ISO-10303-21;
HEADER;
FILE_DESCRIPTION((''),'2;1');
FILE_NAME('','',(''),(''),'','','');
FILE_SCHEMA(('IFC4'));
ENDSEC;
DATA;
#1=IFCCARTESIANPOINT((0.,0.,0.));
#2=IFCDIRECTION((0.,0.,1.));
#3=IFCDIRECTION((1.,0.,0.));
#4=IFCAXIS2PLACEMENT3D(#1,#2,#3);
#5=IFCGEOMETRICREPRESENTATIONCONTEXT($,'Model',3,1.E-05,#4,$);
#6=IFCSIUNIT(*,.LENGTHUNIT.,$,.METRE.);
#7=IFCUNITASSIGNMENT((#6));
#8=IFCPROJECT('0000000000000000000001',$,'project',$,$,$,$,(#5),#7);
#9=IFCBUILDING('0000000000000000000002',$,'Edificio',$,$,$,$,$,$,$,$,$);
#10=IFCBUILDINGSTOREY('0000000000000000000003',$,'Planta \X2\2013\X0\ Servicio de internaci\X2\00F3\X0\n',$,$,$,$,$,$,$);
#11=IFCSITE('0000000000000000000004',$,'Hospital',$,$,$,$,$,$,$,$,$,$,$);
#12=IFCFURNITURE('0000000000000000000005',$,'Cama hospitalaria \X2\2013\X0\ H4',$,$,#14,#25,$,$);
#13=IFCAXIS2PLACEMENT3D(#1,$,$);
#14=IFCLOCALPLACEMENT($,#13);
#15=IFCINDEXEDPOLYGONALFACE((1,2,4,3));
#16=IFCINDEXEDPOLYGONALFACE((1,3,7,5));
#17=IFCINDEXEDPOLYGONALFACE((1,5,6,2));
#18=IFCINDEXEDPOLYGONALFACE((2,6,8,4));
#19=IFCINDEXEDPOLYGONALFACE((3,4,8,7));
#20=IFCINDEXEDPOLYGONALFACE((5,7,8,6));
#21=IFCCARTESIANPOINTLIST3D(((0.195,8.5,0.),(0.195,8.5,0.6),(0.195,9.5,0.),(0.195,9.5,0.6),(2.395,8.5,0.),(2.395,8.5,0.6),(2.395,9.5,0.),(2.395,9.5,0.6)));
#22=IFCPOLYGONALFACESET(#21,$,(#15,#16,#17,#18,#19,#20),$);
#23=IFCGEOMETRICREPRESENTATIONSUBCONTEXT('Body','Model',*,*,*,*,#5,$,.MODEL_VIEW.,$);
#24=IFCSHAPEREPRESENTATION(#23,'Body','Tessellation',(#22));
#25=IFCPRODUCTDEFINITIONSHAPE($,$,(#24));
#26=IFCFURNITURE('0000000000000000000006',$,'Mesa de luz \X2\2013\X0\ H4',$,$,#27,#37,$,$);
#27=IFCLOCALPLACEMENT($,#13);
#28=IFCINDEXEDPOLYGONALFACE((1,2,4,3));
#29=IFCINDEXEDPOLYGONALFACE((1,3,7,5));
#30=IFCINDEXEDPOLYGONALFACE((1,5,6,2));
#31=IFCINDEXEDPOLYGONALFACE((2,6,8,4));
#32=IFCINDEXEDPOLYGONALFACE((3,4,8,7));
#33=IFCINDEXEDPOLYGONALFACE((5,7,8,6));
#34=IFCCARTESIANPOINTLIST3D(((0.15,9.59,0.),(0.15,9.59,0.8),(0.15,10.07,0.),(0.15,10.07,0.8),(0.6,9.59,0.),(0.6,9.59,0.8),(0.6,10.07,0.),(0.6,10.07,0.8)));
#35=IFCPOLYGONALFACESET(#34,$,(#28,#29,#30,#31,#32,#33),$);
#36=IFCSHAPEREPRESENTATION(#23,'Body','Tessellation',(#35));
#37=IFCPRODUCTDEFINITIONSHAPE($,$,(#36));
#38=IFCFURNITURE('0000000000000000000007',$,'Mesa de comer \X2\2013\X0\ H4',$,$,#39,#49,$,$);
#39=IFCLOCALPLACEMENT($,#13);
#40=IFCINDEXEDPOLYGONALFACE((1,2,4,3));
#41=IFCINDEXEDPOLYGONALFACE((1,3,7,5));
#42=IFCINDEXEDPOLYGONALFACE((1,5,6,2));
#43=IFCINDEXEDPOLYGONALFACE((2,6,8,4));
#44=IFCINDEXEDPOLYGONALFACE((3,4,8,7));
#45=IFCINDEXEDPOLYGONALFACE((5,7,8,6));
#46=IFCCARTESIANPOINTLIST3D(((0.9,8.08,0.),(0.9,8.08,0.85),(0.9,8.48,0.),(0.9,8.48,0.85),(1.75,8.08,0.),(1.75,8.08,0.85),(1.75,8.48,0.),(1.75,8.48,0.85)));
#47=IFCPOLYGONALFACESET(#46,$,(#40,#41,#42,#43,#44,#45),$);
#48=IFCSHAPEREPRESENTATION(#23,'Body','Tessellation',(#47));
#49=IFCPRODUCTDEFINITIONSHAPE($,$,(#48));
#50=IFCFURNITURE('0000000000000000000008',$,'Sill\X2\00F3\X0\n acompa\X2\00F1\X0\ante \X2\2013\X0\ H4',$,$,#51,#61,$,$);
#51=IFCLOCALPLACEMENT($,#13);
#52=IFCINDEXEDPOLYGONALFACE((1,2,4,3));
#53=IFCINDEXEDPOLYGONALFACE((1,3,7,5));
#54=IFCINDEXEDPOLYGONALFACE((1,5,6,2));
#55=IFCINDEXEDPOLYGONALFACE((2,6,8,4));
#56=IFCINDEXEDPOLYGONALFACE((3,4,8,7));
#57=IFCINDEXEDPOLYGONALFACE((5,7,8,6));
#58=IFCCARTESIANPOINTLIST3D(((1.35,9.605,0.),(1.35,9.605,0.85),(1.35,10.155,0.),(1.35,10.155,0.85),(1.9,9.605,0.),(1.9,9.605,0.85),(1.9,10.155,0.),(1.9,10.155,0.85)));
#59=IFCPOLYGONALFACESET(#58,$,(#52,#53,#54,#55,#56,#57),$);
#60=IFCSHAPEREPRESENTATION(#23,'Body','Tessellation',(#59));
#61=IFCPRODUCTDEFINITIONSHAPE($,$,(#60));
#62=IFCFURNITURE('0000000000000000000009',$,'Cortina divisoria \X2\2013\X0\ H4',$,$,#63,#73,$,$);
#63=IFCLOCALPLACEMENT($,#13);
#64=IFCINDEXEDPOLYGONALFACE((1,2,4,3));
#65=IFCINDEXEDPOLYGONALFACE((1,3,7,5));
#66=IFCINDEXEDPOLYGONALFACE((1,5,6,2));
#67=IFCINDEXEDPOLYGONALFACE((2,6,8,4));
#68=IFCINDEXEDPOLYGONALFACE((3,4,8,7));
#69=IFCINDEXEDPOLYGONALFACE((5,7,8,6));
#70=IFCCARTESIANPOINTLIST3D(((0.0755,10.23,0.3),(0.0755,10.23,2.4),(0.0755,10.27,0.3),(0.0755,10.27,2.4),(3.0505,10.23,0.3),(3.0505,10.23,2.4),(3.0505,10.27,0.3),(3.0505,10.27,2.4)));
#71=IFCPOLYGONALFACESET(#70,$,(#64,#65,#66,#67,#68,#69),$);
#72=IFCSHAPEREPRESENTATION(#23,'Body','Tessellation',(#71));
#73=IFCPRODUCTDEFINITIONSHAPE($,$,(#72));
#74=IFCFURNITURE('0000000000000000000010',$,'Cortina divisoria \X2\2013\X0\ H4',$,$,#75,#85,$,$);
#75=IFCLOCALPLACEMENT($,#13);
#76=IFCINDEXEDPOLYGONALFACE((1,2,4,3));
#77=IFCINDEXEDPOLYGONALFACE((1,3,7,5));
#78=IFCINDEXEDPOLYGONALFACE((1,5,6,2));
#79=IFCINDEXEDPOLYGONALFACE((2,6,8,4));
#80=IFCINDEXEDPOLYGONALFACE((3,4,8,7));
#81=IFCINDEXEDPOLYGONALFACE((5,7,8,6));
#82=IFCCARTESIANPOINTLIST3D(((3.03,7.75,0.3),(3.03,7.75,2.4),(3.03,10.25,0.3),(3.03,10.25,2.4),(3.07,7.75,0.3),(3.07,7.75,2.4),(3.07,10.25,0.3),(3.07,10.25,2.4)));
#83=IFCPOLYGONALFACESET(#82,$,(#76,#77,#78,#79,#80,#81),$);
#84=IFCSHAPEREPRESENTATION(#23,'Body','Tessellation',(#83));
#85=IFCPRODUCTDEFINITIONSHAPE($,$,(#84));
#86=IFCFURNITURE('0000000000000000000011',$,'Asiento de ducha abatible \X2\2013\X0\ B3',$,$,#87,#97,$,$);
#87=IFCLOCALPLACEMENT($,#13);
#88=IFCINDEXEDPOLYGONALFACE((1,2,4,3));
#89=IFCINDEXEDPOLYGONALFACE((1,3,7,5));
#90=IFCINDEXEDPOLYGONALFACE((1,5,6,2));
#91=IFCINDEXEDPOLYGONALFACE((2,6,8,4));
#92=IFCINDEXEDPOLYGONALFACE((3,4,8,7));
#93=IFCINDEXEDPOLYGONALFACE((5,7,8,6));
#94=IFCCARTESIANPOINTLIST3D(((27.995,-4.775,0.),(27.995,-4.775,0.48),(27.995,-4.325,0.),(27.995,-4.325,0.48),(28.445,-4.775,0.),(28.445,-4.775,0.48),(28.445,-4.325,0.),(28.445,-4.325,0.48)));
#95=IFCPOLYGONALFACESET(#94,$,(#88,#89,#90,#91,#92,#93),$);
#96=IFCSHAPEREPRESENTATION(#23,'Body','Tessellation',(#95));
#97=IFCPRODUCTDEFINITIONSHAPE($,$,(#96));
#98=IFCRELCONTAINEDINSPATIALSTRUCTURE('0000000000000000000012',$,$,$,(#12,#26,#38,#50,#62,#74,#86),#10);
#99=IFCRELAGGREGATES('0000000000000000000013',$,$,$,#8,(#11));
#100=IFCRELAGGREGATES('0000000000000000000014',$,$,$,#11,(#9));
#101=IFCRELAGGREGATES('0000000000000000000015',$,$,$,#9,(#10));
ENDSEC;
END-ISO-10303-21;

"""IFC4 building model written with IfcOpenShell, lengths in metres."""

from ifc_helpers import new_model, si_unit, frame, origin_with_axes, context, subcontext, project, spatial, line, indexed_curve, outline, extrude, element, save


model = new_model("IFC4")

# Units and contexts
model_context = context("Model", 3, precision=1e-05, world=origin_with_axes())
body_context = subcontext(model_context, "Body", "Model", "MODEL_VIEW")
ifc_project = project(units=[si_unit("LENGTHUNIT", "METRE")], contexts=[model_context])

# Site, building, storey
site = spatial("IfcSite", under=ifc_project, Name="Hospital")
building = spatial("IfcBuilding", under=site, Name="Edificio")
storey = spatial("IfcBuildingStorey", under=building, Name="Planta – Servicio de internación")

# Furniture
element("IfcFurniture", 1, inside=storey, Name="Cama hospitalaria – H4", context=body_context, shape_type="SweptSolid", body=[
    extrude(outline(indexed_curve([(0.0, 0.0), (2.2, 0.0), (2.2, 1.0), (0.0, 1.0)], segments=[line(1, 2, 3, 4, 1)])), frame((0.195, 8.5, 0.0), z_axis=(0.0, 0.0, 1.0), x_axis=(1.0, 0.0, 0.0)), (0.0, 0.0, 1.0), 0.6),
])
element("IfcFurniture", 2, inside=storey, Name="Mesa de luz – H4", context=body_context, shape_type="SweptSolid", body=[
    extrude(outline(indexed_curve([(0.0, 0.0), (0.45, 0.0), (0.45, 0.48), (0.0, 0.48)], segments=[line(1, 2, 3, 4, 1)])), frame((0.15, 9.59, 0.0), z_axis=(0.0, 0.0, 1.0), x_axis=(1.0, 0.0, 0.0)), (0.0, 0.0, 1.0), 0.8),
])
element("IfcFurniture", 3, inside=storey, Name="Mesa de comer – H4", context=body_context, shape_type="SweptSolid", body=[
    extrude(outline(indexed_curve([(0.0, 0.0), (0.85, 0.0), (0.85, 0.4), (0.0, 0.4)], segments=[line(1, 2, 3, 4, 1)])), frame((0.9, 8.08, 0.0), z_axis=(0.0, 0.0, 1.0), x_axis=(1.0, 0.0, 0.0)), (0.0, 0.0, 1.0), 0.85),
])
element("IfcFurniture", 4, inside=storey, Name="Sillón acompañante – H4", context=body_context, shape_type="SweptSolid", body=[
    extrude(outline(indexed_curve([(0.0, 0.0), (0.55, 0.0), (0.55, 0.55), (0.0, 0.55)], segments=[line(1, 2, 3, 4, 1)])), frame((1.35, 9.605, 0.0), z_axis=(0.0, 0.0, 1.0), x_axis=(1.0, 0.0, 0.0)), (0.0, 0.0, 1.0), 0.85),
])
element("IfcFurniture", 5, inside=storey, Name="Cortina divisoria – H4", context=body_context, shape_type="SweptSolid", body=[
    extrude(outline(indexed_curve([(0.0, 0.0), (2.975, 0.0), (2.975, 0.04), (0.0, 0.04)], segments=[line(1, 2, 3, 4, 1)])), frame((0.0755, 10.23, 0.3), z_axis=(0.0, 0.0, 1.0), x_axis=(1.0, 0.0, 0.0)), (0.0, 0.0, 1.0), 2.1),
])
element("IfcFurniture", 6, inside=storey, Name="Cortina divisoria – H4", context=body_context, shape_type="SweptSolid", body=[
    extrude(outline(indexed_curve([(0.0, 0.0), (0.04, 0.0), (0.04, 2.5), (0.0, 2.5)], segments=[line(1, 2, 3, 4, 1)])), frame((3.03, 7.75, 0.3), z_axis=(0.0, 0.0, 1.0), x_axis=(1.0, 0.0, 0.0)), (0.0, 0.0, 1.0), 2.1),
])
element("IfcFurniture", 7, inside=storey, Name="Asiento de ducha abatible – B3", context=body_context, shape_type="SweptSolid", body=[
    extrude(outline(indexed_curve([(0.0, 0.0), (0.45, 0.0), (0.45, 0.45), (0.0, 0.45)], segments=[line(1, 2, 3, 4, 1)])), frame((27.995, -4.775, 0.0), z_axis=(0.0, 0.0, 1.0), x_axis=(1.0, 0.0, 0.0)), (0.0, 0.0, 1.0), 0.48),
])

save(model, "model.ifc")
